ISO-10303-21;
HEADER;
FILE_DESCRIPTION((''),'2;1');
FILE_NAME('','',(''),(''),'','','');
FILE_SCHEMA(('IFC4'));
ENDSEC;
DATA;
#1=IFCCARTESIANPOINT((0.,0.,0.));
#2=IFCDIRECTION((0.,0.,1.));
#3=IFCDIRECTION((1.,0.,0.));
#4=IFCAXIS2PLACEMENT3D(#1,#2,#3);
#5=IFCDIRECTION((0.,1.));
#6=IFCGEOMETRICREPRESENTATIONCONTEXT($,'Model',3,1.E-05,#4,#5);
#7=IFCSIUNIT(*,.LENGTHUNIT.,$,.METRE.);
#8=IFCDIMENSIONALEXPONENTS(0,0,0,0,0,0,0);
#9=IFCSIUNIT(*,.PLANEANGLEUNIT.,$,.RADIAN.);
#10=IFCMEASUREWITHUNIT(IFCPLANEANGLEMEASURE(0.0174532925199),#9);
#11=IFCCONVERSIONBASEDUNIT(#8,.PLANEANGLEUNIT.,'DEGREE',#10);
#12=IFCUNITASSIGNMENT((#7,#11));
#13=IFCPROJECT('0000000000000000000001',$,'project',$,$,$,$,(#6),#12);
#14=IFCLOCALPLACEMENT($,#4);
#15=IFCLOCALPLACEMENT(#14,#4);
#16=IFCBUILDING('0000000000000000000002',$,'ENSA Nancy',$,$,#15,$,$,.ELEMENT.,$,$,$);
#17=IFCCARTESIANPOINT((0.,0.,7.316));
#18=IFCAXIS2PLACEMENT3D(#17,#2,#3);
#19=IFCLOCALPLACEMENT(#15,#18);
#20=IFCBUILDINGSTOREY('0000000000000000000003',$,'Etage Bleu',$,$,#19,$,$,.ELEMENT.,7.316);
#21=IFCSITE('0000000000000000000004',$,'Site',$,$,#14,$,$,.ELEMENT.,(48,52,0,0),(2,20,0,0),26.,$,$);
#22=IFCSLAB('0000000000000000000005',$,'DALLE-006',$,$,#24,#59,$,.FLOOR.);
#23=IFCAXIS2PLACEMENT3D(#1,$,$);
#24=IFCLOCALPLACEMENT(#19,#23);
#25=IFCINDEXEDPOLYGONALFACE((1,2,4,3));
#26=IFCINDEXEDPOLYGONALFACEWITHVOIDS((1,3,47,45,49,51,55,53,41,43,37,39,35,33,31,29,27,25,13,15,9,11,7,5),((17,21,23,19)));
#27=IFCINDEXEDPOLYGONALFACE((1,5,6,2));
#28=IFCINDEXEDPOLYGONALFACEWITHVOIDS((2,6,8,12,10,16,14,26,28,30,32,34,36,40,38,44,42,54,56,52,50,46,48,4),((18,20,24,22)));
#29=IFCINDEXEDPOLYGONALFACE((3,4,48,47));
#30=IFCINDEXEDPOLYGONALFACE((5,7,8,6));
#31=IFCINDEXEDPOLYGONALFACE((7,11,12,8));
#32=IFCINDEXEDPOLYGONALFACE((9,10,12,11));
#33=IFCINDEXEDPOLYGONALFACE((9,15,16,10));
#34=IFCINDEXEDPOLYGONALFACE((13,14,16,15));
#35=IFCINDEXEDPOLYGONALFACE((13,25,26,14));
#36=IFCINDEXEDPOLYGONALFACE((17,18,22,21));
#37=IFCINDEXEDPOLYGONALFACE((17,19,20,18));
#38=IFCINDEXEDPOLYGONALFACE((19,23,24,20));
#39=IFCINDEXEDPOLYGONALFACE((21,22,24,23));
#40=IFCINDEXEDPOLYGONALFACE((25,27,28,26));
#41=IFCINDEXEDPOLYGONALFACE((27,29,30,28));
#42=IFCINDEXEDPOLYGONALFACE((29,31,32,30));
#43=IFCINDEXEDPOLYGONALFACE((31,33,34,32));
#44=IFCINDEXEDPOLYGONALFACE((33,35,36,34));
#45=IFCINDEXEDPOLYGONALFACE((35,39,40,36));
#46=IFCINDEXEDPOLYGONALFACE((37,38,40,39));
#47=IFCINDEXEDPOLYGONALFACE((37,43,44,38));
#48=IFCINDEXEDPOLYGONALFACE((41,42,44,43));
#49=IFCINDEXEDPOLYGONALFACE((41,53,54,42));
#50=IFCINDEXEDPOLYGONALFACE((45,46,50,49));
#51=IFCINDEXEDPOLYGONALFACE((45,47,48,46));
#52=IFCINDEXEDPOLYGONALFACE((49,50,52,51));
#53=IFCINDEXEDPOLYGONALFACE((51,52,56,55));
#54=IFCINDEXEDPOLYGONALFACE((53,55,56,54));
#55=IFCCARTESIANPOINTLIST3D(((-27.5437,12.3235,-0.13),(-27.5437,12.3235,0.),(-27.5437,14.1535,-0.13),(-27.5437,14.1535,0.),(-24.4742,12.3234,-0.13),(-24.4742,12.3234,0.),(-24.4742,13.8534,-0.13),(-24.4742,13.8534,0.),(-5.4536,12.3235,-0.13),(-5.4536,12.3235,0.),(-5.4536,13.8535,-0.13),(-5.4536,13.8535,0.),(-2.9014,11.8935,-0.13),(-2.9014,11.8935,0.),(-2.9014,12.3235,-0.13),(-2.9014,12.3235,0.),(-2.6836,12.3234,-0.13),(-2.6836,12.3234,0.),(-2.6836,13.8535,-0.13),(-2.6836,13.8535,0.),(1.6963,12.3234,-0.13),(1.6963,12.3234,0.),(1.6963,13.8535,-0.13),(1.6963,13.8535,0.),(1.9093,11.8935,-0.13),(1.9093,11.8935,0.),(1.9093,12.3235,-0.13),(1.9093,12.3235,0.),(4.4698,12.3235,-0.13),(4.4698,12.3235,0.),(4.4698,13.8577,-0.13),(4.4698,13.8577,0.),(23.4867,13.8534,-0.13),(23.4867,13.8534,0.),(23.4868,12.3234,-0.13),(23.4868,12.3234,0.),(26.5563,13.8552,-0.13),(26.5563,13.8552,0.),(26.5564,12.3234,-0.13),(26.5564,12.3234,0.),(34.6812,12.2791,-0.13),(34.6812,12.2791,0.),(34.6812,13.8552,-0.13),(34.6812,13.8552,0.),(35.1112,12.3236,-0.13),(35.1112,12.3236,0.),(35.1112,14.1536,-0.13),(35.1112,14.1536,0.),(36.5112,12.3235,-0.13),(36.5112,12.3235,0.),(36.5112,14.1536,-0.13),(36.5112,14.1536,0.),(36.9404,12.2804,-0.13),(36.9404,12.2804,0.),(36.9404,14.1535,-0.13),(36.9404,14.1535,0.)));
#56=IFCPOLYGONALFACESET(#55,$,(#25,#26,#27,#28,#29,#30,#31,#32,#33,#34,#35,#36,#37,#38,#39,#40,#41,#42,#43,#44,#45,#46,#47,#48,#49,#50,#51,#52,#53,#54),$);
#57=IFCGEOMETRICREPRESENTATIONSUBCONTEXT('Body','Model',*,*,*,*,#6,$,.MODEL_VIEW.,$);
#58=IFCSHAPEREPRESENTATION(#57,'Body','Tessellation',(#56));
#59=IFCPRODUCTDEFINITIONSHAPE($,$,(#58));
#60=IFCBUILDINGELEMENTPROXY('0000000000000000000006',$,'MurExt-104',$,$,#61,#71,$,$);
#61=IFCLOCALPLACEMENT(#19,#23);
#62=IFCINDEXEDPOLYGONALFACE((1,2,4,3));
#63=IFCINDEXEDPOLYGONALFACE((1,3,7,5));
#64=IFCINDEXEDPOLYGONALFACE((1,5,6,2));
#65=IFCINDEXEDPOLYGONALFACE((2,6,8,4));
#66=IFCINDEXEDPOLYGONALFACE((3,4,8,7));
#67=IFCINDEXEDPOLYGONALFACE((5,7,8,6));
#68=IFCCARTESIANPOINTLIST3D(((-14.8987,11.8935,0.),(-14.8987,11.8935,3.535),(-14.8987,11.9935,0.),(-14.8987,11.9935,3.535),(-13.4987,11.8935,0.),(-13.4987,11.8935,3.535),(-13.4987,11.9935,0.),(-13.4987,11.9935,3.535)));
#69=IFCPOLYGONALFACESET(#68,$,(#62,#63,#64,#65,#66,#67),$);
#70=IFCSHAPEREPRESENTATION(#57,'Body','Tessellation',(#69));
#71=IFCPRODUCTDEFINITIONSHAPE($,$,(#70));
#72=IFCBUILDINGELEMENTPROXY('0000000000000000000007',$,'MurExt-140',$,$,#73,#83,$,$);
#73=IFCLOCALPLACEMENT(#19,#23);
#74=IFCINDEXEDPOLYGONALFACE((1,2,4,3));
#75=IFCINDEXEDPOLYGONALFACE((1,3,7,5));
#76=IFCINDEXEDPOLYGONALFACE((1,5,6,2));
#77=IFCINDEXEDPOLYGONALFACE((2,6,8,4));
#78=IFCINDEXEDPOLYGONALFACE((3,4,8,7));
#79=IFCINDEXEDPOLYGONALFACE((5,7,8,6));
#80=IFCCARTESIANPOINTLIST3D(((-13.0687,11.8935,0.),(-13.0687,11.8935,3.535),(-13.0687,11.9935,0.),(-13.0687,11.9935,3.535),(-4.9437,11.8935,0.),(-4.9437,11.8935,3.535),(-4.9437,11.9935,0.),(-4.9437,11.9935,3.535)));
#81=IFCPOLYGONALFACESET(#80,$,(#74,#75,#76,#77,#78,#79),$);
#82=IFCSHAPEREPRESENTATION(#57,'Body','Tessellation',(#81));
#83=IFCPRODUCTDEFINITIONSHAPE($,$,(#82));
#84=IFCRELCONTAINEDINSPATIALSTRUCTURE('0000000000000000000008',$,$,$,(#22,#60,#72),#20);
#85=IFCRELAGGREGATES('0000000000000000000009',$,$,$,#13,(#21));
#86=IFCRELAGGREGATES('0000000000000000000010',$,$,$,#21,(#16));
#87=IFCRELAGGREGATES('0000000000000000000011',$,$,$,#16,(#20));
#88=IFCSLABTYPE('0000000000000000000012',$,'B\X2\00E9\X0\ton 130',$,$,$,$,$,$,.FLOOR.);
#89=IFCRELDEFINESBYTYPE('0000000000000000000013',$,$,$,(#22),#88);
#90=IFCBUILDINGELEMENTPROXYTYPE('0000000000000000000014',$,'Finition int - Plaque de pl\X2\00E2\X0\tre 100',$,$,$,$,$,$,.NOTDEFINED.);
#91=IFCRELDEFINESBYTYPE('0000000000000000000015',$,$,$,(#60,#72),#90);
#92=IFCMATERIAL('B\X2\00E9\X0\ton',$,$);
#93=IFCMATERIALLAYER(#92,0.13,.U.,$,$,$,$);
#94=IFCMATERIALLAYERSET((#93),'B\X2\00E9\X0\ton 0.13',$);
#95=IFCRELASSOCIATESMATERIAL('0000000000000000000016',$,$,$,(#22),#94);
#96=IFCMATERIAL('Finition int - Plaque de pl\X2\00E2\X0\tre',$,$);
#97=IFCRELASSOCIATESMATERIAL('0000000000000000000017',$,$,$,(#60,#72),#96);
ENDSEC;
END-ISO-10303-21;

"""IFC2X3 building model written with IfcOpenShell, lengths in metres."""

from ifc_helpers import new_model, entity, si_unit, converted_unit, direction, frame, origin_with_axes, place, context, subcontext, project, spatial, polyline, outline, extrude, material, layer, layer_set, layer_usage, type_object, element, save


model = new_model("IFC2X3")

# Units and contexts
model_context = context("Model", 3, precision=1e-05, world=origin_with_axes(), true_north=direction((0.0, 1.0)))
body_context = subcontext(model_context, "Body", "Model", "MODEL_VIEW")
ifc_project = project(units=[si_unit("LENGTHUNIT", "METRE"), converted_unit("PLANEANGLEUNIT", "DEGREE", entity("IfcPlaneAngleMeasure", 0.0174532925199), si_unit("PLANEANGLEUNIT", "RADIAN"), dimensions=[0, 0, 0, 0, 0, 0, 0])], contexts=[model_context])

# Site, building, storey
site_placement = place(None, origin_with_axes())
site = spatial("IfcSite", under=ifc_project, at=site_placement, Name="Site", CompositionType="ELEMENT", RefLatitude=(48, 52, 0, 0), RefLongitude=(2, 20, 0, 0), RefElevation=26.0)
building_placement = place(site_placement, origin_with_axes())
building = spatial("IfcBuilding", under=site, at=building_placement, Name="ENSA Nancy", CompositionType="ELEMENT")
storey_placement = place(building_placement, frame((0.0, 0.0, 7.316), z_axis=(0.0, 0.0, 1.0), x_axis=(1.0, 0.0, 0.0)))
storey = spatial("IfcBuildingStorey", under=building, at=storey_placement, Name="Etage Bleu", CompositionType="ELEMENT", Elevation=7.316)

# Slab, opening
ifc_material_1 = material(Name="Béton")
ifc_layer = layer(ifc_material_1, 0.13, ventilated="UNKNOWN")
ifc_layer_set = layer_set([ifc_layer], Name="Béton 0.13")
ifc_layer_usage = layer_usage(ifc_layer_set, "AXIS3", "NEGATIVE", 0.13)
slab_type = type_object("IfcSlabType", Name="Béton 130", PredefinedType="FLOOR")
slab_placement = place(storey_placement, frame((-27.5437, 13.8535, 0.0), z_axis=(0.0, 0.0, 1.0), x_axis=(1.0, 0.0, 0.0)))
slab = element("IfcSlab", 1, at=slab_placement, inside=storey, type_object=slab_type, material=ifc_layer_usage, Name="DALLE-006", PredefinedType="FLOOR", context=body_context, shape_type="SweptSolid", body=[
    extrude(outline(polyline([(0.0, -1.53), (3.0695, -1.53), (3.0695, 0.0), (22.0902, 0.0), (22.0902, -1.53), (24.6423, -1.53), (24.6423, -1.96), (29.453, -1.96), (29.453, -1.53), (32.0135, -1.53), (32.0135, 0.0042), (51.0305, 0.0), (51.0305, -1.53), (54.1001, -1.53), (54.1, 0.0018), (62.2249, 0.0018), (62.2249, -1.5744), (64.4841, -1.5731), (64.4841, 0.3), (64.0549, 0.3001), (64.0549, -1.53), (62.6549, -1.5299), (62.6549, 0.3001), (0.0, 0.3), (0.0, -1.53)])), frame((0.0, 0.0, -0.13), z_axis=(0.0, 0.0, 1.0), x_axis=(1.0, 0.0, 0.0)), (0.0, 0.0, 1.0), 0.13),
])
opening_placement = place(slab_placement, frame((24.8601, 0.0001, 0.0), z_axis=(0.0, 0.0, 1.0), x_axis=(0.0, -1.0, 0.0)))
element("IfcOpeningElement", 2, at=opening_placement, cuts=slab, context=body_context, shape_type="SweptSolid", body=[
    extrude(outline(polyline([(0.0, 0.0), (1.5301, 0.0), (1.5301, 4.3799), (0.0, 4.3799), (0.0, 0.0)])), frame((0.0, 0.0, -0.13), z_axis=(0.0, 0.0, 1.0), x_axis=(1.0, 0.0, 0.0)), (0.0, 0.0, 1.0), 0.13),
])

# Building element proxies
ifc_material_2 = material(Name="Finition int - Plaque de plâtre")
building_element_proxy_type_1 = type_object("IfcBuildingElementProxyType", Name="Finition int - Plaque de plâtre 100", PredefinedType="NOTDEFINED")
proxy_1_placement = place(storey_placement, frame((-14.8987, 11.8935, 0.0), z_axis=(0.0, 0.0, 1.0), x_axis=(1.0, 0.0, 0.0)))
element("IfcBuildingElementProxy", 3, at=proxy_1_placement, inside=storey, type_object=building_element_proxy_type_1, material=ifc_material_2, Name="MurExt-104", context=body_context, shape_type="SweptSolid", body=[
    extrude(outline(polyline([(0.0, 0.0), (1.4, 0.0), (1.4, 0.1), (0.0, 0.1), (0.0, 0.0)])), origin_with_axes(), (0.0, 0.0, 1.0), 3.535),
])
proxy_2_placement = place(storey_placement, frame((-13.0687, 11.8935, 0.0), z_axis=(0.0, 0.0, 1.0), x_axis=(1.0, 0.0, 0.0)))
element("IfcBuildingElementProxy", 4, at=proxy_2_placement, inside=storey, type_object=building_element_proxy_type_1, material=ifc_material_2, Name="MurExt-140", context=body_context, shape_type="SweptSolid", body=[
    extrude(outline(polyline([(0.0, 0.0), (8.125, 0.0), (8.125, 0.1), (0.0, 0.1), (0.0, 0.0)])), origin_with_axes(), (0.0, 0.0, 1.0), 3.535),
])

save(model, "model.ifc")
